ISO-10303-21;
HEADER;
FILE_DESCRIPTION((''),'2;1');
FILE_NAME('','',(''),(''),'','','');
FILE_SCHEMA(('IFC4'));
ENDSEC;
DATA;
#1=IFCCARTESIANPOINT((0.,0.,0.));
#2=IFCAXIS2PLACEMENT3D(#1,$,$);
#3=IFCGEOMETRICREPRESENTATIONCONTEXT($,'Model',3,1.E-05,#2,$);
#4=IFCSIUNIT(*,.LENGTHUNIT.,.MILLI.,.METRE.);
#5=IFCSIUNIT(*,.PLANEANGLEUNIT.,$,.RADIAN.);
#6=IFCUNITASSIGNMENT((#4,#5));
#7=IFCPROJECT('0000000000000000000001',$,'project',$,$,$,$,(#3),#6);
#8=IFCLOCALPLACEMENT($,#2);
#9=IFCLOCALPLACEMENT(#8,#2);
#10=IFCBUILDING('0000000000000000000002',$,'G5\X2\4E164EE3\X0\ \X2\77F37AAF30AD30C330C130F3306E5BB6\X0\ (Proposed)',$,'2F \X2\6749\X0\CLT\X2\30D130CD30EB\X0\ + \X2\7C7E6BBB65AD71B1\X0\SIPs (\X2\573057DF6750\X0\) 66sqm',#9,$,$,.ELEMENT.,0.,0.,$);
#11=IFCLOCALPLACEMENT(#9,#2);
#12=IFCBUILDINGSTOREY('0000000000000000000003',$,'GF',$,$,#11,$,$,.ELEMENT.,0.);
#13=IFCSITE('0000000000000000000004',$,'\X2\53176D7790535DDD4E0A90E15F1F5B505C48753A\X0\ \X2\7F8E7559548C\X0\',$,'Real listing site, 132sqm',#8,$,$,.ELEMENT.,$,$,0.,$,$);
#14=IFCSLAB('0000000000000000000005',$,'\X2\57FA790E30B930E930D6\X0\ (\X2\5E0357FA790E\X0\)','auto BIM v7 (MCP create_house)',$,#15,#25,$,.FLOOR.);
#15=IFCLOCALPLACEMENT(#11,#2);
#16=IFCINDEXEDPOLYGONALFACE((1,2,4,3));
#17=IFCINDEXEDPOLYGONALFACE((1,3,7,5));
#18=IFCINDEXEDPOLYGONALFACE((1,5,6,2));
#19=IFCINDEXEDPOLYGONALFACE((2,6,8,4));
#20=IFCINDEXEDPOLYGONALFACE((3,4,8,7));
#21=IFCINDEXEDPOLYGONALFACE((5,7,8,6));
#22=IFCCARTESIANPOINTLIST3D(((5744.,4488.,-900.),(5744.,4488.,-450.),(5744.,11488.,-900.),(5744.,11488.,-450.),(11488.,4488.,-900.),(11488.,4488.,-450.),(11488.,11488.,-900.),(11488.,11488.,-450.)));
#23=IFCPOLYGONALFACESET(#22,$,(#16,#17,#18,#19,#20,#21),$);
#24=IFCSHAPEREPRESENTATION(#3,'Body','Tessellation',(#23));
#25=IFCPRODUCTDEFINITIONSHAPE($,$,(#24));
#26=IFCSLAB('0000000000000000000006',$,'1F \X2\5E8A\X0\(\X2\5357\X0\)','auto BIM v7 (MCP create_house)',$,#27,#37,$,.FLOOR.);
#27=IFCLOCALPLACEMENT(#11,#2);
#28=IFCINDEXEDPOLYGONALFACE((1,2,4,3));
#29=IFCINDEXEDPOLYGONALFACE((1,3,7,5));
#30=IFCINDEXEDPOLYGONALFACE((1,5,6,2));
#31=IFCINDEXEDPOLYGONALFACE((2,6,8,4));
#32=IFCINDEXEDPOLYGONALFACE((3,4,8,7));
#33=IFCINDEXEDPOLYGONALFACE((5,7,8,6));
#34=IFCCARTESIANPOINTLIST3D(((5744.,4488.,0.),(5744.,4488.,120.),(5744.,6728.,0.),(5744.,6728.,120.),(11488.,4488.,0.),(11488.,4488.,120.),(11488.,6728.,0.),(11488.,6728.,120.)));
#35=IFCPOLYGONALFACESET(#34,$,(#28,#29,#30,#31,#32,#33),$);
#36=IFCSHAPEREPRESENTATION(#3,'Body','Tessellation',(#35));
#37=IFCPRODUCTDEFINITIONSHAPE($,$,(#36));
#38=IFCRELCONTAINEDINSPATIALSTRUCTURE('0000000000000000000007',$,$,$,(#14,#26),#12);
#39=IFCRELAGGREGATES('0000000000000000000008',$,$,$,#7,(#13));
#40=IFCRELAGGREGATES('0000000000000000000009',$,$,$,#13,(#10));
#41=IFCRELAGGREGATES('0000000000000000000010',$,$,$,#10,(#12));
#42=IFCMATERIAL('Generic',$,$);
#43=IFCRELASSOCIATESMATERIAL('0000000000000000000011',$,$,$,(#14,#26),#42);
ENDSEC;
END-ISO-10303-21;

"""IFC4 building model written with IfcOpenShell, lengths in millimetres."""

from ifc_helpers import new_model, si_unit, frame, frame_2d, origin, place, context, project, spatial, rectangle, extrude, material, element, save


model = new_model("IFC4")

# Units and contexts
model_context = context("Model", 3, precision=1e-05, world=origin())
ifc_project = project(units=[si_unit("LENGTHUNIT", "METRE", prefix="MILLI"), si_unit("PLANEANGLEUNIT", "RADIAN")], contexts=[model_context])

# Site, building, storey
site_placement = place(None, origin())
site = spatial("IfcSite", under=ifc_project, at=site_placement, Name="北海道川上郡弟子屈町 美留和", ObjectType="Real listing site, 132sqm", CompositionType="ELEMENT", RefElevation=0.0)
building_placement = place(site_placement, origin())
building = spatial("IfcBuilding", under=site, at=building_placement, Name="G5世代 石窯キッチンの家 (Proposed)", ObjectType="2F 杉CLTパネル + 籾殻断熱SIPs (地域材) 66sqm", CompositionType="ELEMENT", ElevationOfRefHeight=0.0, ElevationOfTerrain=0.0)
storey_placement = place(building_placement, origin())
storey = spatial("IfcBuildingStorey", under=building, at=storey_placement, Name="GF", CompositionType="ELEMENT", Elevation=0.0)

# Slabs
ifc_material = material(Name="Generic")
slab_1_placement = place(storey_placement, frame((2872.0, 2244.0, -450.0)))
element("IfcSlab", 1, at=slab_1_placement, inside=storey, material=ifc_material, Name="基礎スラブ (布基礎)", Description="auto BIM v7 (MCP create_house)", PredefinedType="FLOOR", context=model_context, shape_type="SweptSolid", body=[
    extrude(rectangle(XDim=5744.0, YDim=7000.0, at=frame_2d((2872.0, 3500.0))), frame((2872.0, 2244.0, -450.0)), (0.0, 0.0, 1.0), 450.0),
])
slab_2_placement = place(storey_placement, frame((2872.0, 2244.0, 0.0)))
element("IfcSlab", 2, at=slab_2_placement, inside=storey, material=ifc_material, Name="1F 床(南)", Description="auto BIM v7 (MCP create_house)", PredefinedType="FLOOR", context=model_context, shape_type="SweptSolid", body=[
    extrude(rectangle(XDim=5744.0, YDim=2240.0, at=frame_2d((2872.0, 1120.0))), frame((2872.0, 2244.0, 0.0)), (0.0, 0.0, 1.0), 120.0),
])

save(model, "model.ifc")
